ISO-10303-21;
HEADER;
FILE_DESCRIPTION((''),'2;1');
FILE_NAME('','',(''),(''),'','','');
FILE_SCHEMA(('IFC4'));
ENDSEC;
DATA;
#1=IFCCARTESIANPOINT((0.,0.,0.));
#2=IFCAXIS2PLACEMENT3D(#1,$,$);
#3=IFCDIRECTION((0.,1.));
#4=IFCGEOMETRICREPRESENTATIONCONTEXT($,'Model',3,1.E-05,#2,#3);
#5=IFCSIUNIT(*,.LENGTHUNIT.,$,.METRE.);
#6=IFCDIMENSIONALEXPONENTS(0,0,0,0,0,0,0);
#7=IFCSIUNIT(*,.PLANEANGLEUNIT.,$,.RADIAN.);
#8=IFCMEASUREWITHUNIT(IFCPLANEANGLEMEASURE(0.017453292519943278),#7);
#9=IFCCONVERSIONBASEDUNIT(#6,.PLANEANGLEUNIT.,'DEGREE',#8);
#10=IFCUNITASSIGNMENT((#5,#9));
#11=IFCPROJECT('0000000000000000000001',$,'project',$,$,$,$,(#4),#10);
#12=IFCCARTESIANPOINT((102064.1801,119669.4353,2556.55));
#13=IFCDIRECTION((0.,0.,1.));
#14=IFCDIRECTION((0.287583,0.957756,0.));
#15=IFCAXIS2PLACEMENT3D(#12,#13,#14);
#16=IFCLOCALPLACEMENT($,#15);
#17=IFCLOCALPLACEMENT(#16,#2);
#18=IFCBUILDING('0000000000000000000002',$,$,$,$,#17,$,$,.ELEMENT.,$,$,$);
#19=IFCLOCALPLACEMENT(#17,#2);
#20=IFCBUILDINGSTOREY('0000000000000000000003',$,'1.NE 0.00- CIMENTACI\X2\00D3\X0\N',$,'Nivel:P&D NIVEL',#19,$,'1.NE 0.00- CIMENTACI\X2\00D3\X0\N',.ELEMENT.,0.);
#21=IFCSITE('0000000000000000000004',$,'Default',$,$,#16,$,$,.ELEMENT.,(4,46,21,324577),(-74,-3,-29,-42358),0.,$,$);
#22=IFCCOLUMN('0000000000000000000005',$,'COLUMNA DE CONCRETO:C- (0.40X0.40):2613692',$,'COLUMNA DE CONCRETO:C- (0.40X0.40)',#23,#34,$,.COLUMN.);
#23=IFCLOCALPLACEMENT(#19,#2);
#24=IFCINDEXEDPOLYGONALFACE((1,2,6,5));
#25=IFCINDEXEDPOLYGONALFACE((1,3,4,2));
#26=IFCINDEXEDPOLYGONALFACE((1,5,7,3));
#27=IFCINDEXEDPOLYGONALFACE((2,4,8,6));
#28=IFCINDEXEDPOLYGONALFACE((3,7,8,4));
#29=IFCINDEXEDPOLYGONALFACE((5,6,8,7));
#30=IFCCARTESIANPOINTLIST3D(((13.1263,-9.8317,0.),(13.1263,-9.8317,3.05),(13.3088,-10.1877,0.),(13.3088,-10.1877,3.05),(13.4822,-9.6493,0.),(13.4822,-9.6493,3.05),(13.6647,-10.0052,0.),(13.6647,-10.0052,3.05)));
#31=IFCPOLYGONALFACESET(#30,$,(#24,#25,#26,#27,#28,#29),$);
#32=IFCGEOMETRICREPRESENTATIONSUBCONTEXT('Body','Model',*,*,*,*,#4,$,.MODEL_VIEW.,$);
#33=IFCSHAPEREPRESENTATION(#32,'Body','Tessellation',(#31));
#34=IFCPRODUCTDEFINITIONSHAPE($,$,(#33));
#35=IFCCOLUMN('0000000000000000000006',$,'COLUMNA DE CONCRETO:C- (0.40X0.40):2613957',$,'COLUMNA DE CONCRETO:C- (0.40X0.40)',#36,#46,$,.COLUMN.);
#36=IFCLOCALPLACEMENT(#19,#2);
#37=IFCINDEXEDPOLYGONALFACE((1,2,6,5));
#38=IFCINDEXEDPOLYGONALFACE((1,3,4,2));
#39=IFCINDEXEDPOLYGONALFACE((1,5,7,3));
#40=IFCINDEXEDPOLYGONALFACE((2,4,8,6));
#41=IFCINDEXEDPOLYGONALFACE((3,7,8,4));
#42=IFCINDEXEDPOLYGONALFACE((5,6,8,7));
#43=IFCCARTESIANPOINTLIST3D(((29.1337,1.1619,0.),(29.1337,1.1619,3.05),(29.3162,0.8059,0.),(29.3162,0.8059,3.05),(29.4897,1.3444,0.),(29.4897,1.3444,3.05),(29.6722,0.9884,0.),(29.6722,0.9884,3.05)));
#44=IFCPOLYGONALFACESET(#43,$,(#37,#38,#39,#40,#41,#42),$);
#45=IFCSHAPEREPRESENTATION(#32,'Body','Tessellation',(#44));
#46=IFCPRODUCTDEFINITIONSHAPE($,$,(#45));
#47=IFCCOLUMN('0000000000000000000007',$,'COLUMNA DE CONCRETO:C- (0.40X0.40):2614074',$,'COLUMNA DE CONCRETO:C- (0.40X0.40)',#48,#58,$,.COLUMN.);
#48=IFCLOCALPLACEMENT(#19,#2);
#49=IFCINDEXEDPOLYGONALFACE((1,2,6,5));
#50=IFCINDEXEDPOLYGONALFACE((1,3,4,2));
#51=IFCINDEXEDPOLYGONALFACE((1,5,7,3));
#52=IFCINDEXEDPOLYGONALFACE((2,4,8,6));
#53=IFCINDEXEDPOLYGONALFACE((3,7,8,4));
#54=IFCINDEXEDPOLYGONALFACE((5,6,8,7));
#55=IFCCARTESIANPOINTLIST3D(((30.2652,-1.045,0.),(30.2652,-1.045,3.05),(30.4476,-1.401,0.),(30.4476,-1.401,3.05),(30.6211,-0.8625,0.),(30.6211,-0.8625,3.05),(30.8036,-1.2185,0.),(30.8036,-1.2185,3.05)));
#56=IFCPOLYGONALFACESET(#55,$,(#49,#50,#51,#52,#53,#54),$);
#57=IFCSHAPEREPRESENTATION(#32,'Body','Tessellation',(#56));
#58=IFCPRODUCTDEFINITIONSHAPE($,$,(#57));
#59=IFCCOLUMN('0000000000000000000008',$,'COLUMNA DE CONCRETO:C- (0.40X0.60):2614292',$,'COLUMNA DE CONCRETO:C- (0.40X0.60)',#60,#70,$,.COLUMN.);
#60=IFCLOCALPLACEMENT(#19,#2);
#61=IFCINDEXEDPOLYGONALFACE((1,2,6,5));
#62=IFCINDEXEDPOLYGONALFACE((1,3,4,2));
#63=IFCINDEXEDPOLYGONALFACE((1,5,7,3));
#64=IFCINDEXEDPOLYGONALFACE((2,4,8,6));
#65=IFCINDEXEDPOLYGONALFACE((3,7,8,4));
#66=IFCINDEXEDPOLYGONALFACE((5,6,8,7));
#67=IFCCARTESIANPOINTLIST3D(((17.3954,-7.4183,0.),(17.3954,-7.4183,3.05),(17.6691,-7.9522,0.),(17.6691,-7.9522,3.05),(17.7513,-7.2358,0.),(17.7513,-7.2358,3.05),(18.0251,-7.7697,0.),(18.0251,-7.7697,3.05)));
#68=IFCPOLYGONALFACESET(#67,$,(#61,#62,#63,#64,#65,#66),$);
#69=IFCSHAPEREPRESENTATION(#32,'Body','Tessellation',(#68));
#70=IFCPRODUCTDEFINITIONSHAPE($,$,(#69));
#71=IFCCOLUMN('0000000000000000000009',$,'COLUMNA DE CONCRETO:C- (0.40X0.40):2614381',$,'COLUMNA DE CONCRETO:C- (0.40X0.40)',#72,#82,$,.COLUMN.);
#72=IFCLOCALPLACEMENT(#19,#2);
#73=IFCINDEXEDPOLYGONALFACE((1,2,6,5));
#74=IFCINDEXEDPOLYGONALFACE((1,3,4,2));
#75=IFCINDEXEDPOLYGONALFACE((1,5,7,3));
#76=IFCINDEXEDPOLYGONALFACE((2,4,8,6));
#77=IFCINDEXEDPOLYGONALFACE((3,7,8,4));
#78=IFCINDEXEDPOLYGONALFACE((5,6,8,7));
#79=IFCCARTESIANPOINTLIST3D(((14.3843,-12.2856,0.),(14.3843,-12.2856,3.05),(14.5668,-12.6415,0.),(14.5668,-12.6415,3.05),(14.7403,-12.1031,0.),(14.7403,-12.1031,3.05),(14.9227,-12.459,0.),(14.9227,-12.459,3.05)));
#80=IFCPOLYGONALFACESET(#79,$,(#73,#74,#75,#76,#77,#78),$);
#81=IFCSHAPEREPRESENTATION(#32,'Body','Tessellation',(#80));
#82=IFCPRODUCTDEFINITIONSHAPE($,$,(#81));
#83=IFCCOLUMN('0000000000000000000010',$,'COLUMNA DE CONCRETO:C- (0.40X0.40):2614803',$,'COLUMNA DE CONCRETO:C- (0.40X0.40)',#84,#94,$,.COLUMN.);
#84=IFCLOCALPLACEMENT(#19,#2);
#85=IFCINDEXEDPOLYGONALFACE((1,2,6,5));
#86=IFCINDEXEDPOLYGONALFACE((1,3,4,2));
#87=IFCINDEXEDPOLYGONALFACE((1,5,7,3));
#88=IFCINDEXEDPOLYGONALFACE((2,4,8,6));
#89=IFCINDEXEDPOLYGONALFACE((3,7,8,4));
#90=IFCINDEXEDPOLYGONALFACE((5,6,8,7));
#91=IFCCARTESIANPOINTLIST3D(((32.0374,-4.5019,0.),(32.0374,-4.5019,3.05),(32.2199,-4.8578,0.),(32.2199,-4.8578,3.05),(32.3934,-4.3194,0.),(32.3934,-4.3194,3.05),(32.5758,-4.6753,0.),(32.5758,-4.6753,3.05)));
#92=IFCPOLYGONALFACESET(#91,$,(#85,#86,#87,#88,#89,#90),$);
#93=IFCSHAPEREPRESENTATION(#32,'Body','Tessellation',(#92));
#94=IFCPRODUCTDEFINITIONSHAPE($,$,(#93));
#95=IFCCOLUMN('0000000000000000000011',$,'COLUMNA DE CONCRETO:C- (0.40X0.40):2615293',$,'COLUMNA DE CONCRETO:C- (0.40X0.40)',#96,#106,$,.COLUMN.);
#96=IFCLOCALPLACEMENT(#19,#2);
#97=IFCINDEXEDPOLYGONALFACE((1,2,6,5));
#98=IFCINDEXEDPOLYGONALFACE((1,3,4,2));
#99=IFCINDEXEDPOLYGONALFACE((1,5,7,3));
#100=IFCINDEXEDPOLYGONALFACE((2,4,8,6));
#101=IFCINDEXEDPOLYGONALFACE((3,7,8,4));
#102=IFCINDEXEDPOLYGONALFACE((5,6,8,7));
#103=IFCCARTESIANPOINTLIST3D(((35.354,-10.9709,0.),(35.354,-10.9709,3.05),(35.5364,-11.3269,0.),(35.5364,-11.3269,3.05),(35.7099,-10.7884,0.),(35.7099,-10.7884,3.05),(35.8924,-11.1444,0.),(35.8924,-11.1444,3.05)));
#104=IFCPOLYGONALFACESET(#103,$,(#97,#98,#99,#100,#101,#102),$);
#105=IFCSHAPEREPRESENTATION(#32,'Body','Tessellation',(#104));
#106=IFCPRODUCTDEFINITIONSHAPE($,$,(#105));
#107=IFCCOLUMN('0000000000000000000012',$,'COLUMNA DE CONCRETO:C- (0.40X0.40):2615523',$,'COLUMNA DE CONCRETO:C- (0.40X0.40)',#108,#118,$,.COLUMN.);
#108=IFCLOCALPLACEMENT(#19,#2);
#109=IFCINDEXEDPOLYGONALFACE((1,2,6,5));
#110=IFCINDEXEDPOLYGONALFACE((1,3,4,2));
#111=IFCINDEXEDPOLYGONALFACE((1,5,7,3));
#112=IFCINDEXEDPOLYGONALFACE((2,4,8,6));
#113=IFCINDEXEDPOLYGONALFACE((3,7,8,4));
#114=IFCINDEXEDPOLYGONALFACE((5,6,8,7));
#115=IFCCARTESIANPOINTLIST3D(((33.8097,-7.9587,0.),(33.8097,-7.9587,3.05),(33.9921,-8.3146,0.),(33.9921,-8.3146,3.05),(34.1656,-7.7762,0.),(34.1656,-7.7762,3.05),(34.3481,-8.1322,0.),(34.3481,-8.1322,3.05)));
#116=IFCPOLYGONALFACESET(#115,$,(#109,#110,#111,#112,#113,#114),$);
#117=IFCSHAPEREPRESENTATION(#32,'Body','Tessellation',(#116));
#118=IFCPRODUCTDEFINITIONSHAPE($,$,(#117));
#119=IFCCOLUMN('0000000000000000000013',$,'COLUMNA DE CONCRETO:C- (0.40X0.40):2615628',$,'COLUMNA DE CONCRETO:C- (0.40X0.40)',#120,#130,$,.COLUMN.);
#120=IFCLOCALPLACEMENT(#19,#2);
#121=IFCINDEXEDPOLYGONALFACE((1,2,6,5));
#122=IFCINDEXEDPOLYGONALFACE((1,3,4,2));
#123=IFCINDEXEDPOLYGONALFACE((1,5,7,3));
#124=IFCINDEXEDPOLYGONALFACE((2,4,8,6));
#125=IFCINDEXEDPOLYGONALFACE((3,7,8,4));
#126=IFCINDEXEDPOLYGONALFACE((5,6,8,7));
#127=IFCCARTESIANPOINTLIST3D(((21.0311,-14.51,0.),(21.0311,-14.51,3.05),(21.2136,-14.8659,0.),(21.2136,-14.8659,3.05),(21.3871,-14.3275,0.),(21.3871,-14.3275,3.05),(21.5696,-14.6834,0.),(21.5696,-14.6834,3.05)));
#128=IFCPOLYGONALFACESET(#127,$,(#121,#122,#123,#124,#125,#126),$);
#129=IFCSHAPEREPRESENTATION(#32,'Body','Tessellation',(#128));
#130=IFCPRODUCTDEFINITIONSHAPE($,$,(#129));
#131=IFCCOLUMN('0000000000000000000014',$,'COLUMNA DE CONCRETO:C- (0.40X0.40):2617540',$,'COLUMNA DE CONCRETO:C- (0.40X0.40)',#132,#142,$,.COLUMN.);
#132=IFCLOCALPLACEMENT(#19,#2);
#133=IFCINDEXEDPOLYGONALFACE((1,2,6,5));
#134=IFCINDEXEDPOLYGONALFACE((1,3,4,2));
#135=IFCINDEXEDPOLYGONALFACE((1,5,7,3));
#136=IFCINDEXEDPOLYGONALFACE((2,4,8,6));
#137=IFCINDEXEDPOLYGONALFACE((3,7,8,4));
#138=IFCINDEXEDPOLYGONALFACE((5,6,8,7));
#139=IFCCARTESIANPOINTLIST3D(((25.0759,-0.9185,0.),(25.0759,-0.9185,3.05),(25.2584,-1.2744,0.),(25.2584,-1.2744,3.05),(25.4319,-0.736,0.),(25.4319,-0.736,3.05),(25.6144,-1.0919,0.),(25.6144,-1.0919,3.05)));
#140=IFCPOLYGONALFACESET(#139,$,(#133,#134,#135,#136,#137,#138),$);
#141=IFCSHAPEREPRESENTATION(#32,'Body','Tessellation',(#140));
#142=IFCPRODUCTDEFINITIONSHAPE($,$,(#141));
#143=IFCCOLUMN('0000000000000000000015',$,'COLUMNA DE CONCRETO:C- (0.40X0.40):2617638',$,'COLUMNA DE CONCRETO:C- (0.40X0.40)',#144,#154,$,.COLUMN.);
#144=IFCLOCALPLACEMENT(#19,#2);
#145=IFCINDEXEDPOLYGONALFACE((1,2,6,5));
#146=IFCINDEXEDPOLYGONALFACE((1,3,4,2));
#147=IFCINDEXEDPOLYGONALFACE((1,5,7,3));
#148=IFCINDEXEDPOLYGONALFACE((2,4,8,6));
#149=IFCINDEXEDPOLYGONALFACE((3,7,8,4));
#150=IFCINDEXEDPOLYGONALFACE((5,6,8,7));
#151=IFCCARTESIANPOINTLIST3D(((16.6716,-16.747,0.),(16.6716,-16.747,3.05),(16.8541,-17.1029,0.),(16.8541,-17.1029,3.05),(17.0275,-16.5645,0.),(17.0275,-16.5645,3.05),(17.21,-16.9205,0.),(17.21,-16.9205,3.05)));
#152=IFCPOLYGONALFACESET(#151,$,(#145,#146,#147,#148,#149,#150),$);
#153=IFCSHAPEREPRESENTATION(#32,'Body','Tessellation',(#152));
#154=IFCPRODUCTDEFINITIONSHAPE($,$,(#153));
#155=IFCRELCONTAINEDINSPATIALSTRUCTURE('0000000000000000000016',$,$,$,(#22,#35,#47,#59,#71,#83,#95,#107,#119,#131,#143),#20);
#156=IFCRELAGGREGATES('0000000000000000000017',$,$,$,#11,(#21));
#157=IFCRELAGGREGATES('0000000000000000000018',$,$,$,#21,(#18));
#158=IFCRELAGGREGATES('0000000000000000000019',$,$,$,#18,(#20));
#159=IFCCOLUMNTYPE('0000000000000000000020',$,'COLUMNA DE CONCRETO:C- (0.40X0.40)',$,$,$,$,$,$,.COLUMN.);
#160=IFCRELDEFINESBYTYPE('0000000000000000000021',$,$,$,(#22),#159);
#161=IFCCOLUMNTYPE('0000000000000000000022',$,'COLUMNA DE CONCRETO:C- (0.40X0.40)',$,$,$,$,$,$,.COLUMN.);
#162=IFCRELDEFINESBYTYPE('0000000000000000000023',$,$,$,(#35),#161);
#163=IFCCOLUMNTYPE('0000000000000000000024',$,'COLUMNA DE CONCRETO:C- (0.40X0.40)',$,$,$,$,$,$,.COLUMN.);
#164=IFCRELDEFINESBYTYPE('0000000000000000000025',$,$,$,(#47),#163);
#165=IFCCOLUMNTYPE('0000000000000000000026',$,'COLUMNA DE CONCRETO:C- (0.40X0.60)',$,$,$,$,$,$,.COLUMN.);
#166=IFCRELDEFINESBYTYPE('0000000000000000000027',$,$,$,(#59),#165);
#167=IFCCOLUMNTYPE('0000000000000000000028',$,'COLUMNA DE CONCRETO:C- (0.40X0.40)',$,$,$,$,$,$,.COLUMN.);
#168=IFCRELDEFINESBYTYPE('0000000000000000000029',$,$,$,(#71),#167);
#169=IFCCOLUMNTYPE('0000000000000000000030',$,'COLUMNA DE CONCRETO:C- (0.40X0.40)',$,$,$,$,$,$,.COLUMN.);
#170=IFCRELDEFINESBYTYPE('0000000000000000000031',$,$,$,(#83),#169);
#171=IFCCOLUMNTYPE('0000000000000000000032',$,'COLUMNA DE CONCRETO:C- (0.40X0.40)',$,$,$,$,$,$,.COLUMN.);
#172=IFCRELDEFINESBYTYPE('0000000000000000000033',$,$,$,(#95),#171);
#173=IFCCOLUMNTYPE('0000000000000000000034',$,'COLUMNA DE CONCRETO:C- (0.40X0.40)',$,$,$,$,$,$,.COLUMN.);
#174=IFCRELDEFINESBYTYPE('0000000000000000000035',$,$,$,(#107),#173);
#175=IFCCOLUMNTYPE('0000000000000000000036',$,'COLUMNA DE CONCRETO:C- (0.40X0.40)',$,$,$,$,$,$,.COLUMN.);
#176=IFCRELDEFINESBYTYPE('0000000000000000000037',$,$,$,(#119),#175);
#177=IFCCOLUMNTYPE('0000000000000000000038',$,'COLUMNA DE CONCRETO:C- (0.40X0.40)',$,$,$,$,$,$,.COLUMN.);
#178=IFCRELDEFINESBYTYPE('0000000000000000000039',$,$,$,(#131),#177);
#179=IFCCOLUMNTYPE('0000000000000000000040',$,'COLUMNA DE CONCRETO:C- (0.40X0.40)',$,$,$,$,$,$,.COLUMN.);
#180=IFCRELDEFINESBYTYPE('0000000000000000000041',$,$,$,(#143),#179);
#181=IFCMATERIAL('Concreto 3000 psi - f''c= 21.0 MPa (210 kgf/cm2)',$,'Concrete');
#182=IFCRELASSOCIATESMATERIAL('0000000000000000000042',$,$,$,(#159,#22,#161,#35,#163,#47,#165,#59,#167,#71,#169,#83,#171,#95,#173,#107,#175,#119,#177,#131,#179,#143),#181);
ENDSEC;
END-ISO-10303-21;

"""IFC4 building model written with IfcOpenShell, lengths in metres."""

from ifc_helpers import new_model, entity, si_unit, converted_unit, direction, frame, origin, place, context, subcontext, project, spatial, indexed_curve, outline, extrude, source, transform, mapped, material, type_object, type_shapes, element, save


model = new_model("IFC4")

# Units and contexts
model_context = context("Model", 3, precision=1e-05, world=origin(), true_north=direction((0.0, 1.0)))
body_context = subcontext(model_context, "Body", "Model", "MODEL_VIEW")
ifc_project = project(units=[si_unit("LENGTHUNIT", "METRE"), converted_unit("PLANEANGLEUNIT", "DEGREE", entity("IfcPlaneAngleMeasure", 0.017453292519943278), si_unit("PLANEANGLEUNIT", "RADIAN"), dimensions=[0, 0, 0, 0, 0, 0, 0])], contexts=[model_context])

# Site, building, storey
site_placement = place(None, frame((102064.1801, 119669.4353, 2556.55), z_axis=(0.0, 0.0, 1.0), x_axis=(0.287583, 0.957756, 0.0)))
site = spatial("IfcSite", under=ifc_project, at=site_placement, Name="Default", CompositionType="ELEMENT", RefLatitude=(4, 46, 21, 324577), RefLongitude=(-74, -3, -29, -42358), RefElevation=0.0)
building_placement = place(site_placement, origin())
building = spatial("IfcBuilding", under=site, at=building_placement, CompositionType="ELEMENT")
storey_placement = place(building_placement, origin())
storey = spatial("IfcBuildingStorey", under=building, at=storey_placement, Name="1.NE 0.00- CIMENTACIÓN", ObjectType="Nivel:P&D NIVEL", LongName="1.NE 0.00- CIMENTACIÓN", CompositionType="ELEMENT", Elevation=0.0)

# Columns
ifc_material = material(Name="Concreto 3000 psi - f'c= 21.0 MPa (210 kgf/cm2)", Category="Concrete")
column_type_1 = type_object("IfcColumnType", Name="COLUMNA DE CONCRETO:C- (0.40X0.40)", PredefinedType="COLUMN", material=ifc_material)
shared_shape_1 = source(origin(), body_context, "Body", "SweptSolid", [
    extrude(outline(indexed_curve([(-0.2, -0.2), (0.2, -0.2), (0.2, 0.2), (-0.2, 0.2), (-0.2, -0.2)], self_intersect=False)), frame((13.3955, -9.9185, 0.0), z_axis=(0.0, 0.0, 1.0), x_axis=(-0.889869, -0.456217, 0.0)), (0.0, 0.0, 1.0), 3.05),
])
type_shapes(column_type_1, [shared_shape_1])
column_1_placement = place(storey_placement, origin())
element("IfcColumn", 1, at=column_1_placement, inside=storey, type_object=column_type_1, material=ifc_material, Name="COLUMNA DE CONCRETO:C- (0.40X0.40):2613692", ObjectType="COLUMNA DE CONCRETO:C- (0.40X0.40)", PredefinedType="COLUMN", context=body_context, shape_type="MappedRepresentation", body=[
    mapped(shared_shape_1, transform((0.0, 0.0, 0.0), scale=1.0)),
])
column_type_2 = type_object("IfcColumnType", Name="COLUMNA DE CONCRETO:C- (0.40X0.40)", PredefinedType="COLUMN", material=ifc_material)
shared_shape_2 = source(origin(), body_context, "Body", "SweptSolid", [
    extrude(outline(indexed_curve([(-0.2, -0.2), (0.2, -0.2), (0.2, 0.2), (-0.2, 0.2), (-0.2, -0.2)], self_intersect=False)), frame((29.403, 1.0751, 0.0), z_axis=(0.0, 0.0, 1.0), x_axis=(-0.889869, -0.456217, 0.0)), (0.0, 0.0, 1.0), 3.05),
])
type_shapes(column_type_2, [shared_shape_2])
column_2_placement = place(storey_placement, origin())
element("IfcColumn", 2, at=column_2_placement, inside=storey, type_object=column_type_2, material=ifc_material, Name="COLUMNA DE CONCRETO:C- (0.40X0.40):2613957", ObjectType="COLUMNA DE CONCRETO:C- (0.40X0.40)", PredefinedType="COLUMN", context=body_context, shape_type="MappedRepresentation", body=[
    mapped(shared_shape_2, transform((0.0, 0.0, 0.0), scale=1.0)),
])
column_type_3 = type_object("IfcColumnType", Name="COLUMNA DE CONCRETO:C- (0.40X0.40)", PredefinedType="COLUMN", material=ifc_material)
shared_shape_3 = source(origin(), body_context, "Body", "SweptSolid", [
    extrude(outline(indexed_curve([(-0.2, -0.2), (0.2, -0.2), (0.2, 0.2), (-0.2, 0.2), (-0.2, -0.2)], self_intersect=False)), frame((30.5344, -1.1317, 0.0), z_axis=(0.0, 0.0, 1.0), x_axis=(-0.889869, -0.456217, 0.0)), (0.0, 0.0, 1.0), 3.05),
])
type_shapes(column_type_3, [shared_shape_3])
column_3_placement = place(storey_placement, origin())
element("IfcColumn", 3, at=column_3_placement, inside=storey, type_object=column_type_3, material=ifc_material, Name="COLUMNA DE CONCRETO:C- (0.40X0.40):2614074", ObjectType="COLUMNA DE CONCRETO:C- (0.40X0.40)", PredefinedType="COLUMN", context=body_context, shape_type="MappedRepresentation", body=[
    mapped(shared_shape_3, transform((0.0, 0.0, 0.0), scale=1.0)),
])
column_type_4 = type_object("IfcColumnType", Name="COLUMNA DE CONCRETO:C- (0.40X0.60)", PredefinedType="COLUMN", material=ifc_material)
shared_shape_4 = source(origin(), body_context, "Body", "SweptSolid", [
    extrude(outline(indexed_curve([(-0.2, -0.3), (0.2, -0.3), (0.2, 0.3), (-0.2, 0.3), (-0.2, -0.3)], self_intersect=False)), frame((17.7102, -7.594, 0.0), z_axis=(0.0, 0.0, 1.0), x_axis=(-0.889869, -0.456217, 0.0)), (0.0, 0.0, 1.0), 3.05),
])
type_shapes(column_type_4, [shared_shape_4])
column_4_placement = place(storey_placement, origin())
element("IfcColumn", 4, at=column_4_placement, inside=storey, type_object=column_type_4, material=ifc_material, Name="COLUMNA DE CONCRETO:C- (0.40X0.60):2614292", ObjectType="COLUMNA DE CONCRETO:C- (0.40X0.60)", PredefinedType="COLUMN", context=body_context, shape_type="MappedRepresentation", body=[
    mapped(shared_shape_4, transform((0.0, 0.0, 0.0), scale=1.0)),
])
column_type_5 = type_object("IfcColumnType", Name="COLUMNA DE CONCRETO:C- (0.40X0.40)", PredefinedType="COLUMN", material=ifc_material)
shared_shape_5 = source(origin(), body_context, "Body", "SweptSolid", [
    extrude(outline(indexed_curve([(-0.2, -0.2), (0.2, -0.2), (0.2, 0.2), (-0.2, 0.2), (-0.2, -0.2)], self_intersect=False)), frame((14.6535, -12.3723, 0.0), z_axis=(0.0, 0.0, 1.0), x_axis=(-0.889869, -0.456217, 0.0)), (0.0, 0.0, 1.0), 3.05),
])
type_shapes(column_type_5, [shared_shape_5])
column_5_placement = place(storey_placement, origin())
element("IfcColumn", 5, at=column_5_placement, inside=storey, type_object=column_type_5, material=ifc_material, Name="COLUMNA DE CONCRETO:C- (0.40X0.40):2614381", ObjectType="COLUMNA DE CONCRETO:C- (0.40X0.40)", PredefinedType="COLUMN", context=body_context, shape_type="MappedRepresentation", body=[
    mapped(shared_shape_5, transform((0.0, 0.0, 0.0), scale=1.0)),
])
column_type_6 = type_object("IfcColumnType", Name="COLUMNA DE CONCRETO:C- (0.40X0.40)", PredefinedType="COLUMN", material=ifc_material)
shared_shape_6 = source(origin(), body_context, "Body", "SweptSolid", [
    extrude(outline(indexed_curve([(-0.2, -0.2), (0.2, -0.2), (0.2, 0.2), (-0.2, 0.2), (-0.2, -0.2)], self_intersect=False)), frame((32.3066, -4.5886, 0.0), z_axis=(0.0, 0.0, 1.0), x_axis=(-0.889869, -0.456217, 0.0)), (0.0, 0.0, 1.0), 3.05),
])
type_shapes(column_type_6, [shared_shape_6])
column_6_placement = place(storey_placement, origin())
element("IfcColumn", 6, at=column_6_placement, inside=storey, type_object=column_type_6, material=ifc_material, Name="COLUMNA DE CONCRETO:C- (0.40X0.40):2614803", ObjectType="COLUMNA DE CONCRETO:C- (0.40X0.40)", PredefinedType="COLUMN", context=body_context, shape_type="MappedRepresentation", body=[
    mapped(shared_shape_6, transform((0.0, 0.0, 0.0), scale=1.0)),
])
column_type_7 = type_object("IfcColumnType", Name="COLUMNA DE CONCRETO:C- (0.40X0.40)", PredefinedType="COLUMN", material=ifc_material)
shared_shape_7 = source(origin(), body_context, "Body", "SweptSolid", [
    extrude(outline(indexed_curve([(-0.2, -0.2), (0.2, -0.2), (0.2, 0.2), (-0.2, 0.2), (-0.2, -0.2)], self_intersect=False)), frame((35.6232, -11.0576, 0.0), z_axis=(0.0, 0.0, 1.0), x_axis=(-0.889869, -0.456217, 0.0)), (0.0, 0.0, 1.0), 3.05),
])
type_shapes(column_type_7, [shared_shape_7])
column_7_placement = place(storey_placement, origin())
element("IfcColumn", 7, at=column_7_placement, inside=storey, type_object=column_type_7, material=ifc_material, Name="COLUMNA DE CONCRETO:C- (0.40X0.40):2615293", ObjectType="COLUMNA DE CONCRETO:C- (0.40X0.40)", PredefinedType="COLUMN", context=body_context, shape_type="MappedRepresentation", body=[
    mapped(shared_shape_7, transform((0.0, 0.0, 0.0), scale=1.0)),
])
column_type_8 = type_object("IfcColumnType", Name="COLUMNA DE CONCRETO:C- (0.40X0.40)", PredefinedType="COLUMN", material=ifc_material)
shared_shape_8 = source(origin(), body_context, "Body", "SweptSolid", [
    extrude(outline(indexed_curve([(-0.2, -0.2), (0.2, -0.2), (0.2, 0.2), (-0.2, 0.2), (-0.2, -0.2)], self_intersect=False)), frame((34.0789, -8.0454, 0.0), z_axis=(0.0, 0.0, 1.0), x_axis=(-0.889869, -0.456217, 0.0)), (0.0, 0.0, 1.0), 3.05),
])
type_shapes(column_type_8, [shared_shape_8])
column_8_placement = place(storey_placement, origin())
element("IfcColumn", 8, at=column_8_placement, inside=storey, type_object=column_type_8, material=ifc_material, Name="COLUMNA DE CONCRETO:C- (0.40X0.40):2615523", ObjectType="COLUMNA DE CONCRETO:C- (0.40X0.40)", PredefinedType="COLUMN", context=body_context, shape_type="MappedRepresentation", body=[
    mapped(shared_shape_8, transform((0.0, 0.0, 0.0), scale=1.0)),
])
column_type_9 = type_object("IfcColumnType", Name="COLUMNA DE CONCRETO:C- (0.40X0.40)", PredefinedType="COLUMN", material=ifc_material)
shared_shape_9 = source(origin(), body_context, "Body", "SweptSolid", [
    extrude(outline(indexed_curve([(-0.2, -0.2), (0.2, -0.2), (0.2, 0.2), (-0.2, 0.2), (-0.2, -0.2)], self_intersect=False)), frame((21.3004, -14.5967, 0.0), z_axis=(0.0, 0.0, 1.0), x_axis=(-0.889869, -0.456217, 0.0)), (0.0, 0.0, 1.0), 3.05),
])
type_shapes(column_type_9, [shared_shape_9])
column_9_placement = place(storey_placement, origin())
element("IfcColumn", 9, at=column_9_placement, inside=storey, type_object=column_type_9, material=ifc_material, Name="COLUMNA DE CONCRETO:C- (0.40X0.40):2615628", ObjectType="COLUMNA DE CONCRETO:C- (0.40X0.40)", PredefinedType="COLUMN", context=body_context, shape_type="MappedRepresentation", body=[
    mapped(shared_shape_9, transform((0.0, 0.0, 0.0), scale=1.0)),
])
column_type_10 = type_object("IfcColumnType", Name="COLUMNA DE CONCRETO:C- (0.40X0.40)", PredefinedType="COLUMN", material=ifc_material)
shared_shape_10 = source(origin(), body_context, "Body", "SweptSolid", [
    extrude(outline(indexed_curve([(-0.2, -0.2), (0.2, -0.2), (0.2, 0.2), (-0.2, 0.2), (-0.2, -0.2)], self_intersect=False)), frame((25.3452, -1.0052, 0.0), z_axis=(0.0, 0.0, 1.0), x_axis=(-0.889869, -0.456217, 0.0)), (0.0, 0.0, 1.0), 3.05),
])
type_shapes(column_type_10, [shared_shape_10])
column_10_placement = place(storey_placement, origin())
element("IfcColumn", 10, at=column_10_placement, inside=storey, type_object=column_type_10, material=ifc_material, Name="COLUMNA DE CONCRETO:C- (0.40X0.40):2617540", ObjectType="COLUMNA DE CONCRETO:C- (0.40X0.40)", PredefinedType="COLUMN", context=body_context, shape_type="MappedRepresentation", body=[
    mapped(shared_shape_10, transform((0.0, 0.0, 0.0), scale=1.0)),
])
column_type_11 = type_object("IfcColumnType", Name="COLUMNA DE CONCRETO:C- (0.40X0.40)", PredefinedType="COLUMN", material=ifc_material)
shared_shape_11 = source(origin(), body_context, "Body", "SweptSolid", [
    extrude(outline(indexed_curve([(-0.2, -0.2), (0.2, -0.2), (0.2, 0.2), (-0.2, 0.2), (-0.2, -0.2)], self_intersect=False)), frame((16.9408, -16.8337, 0.0), z_axis=(0.0, 0.0, 1.0), x_axis=(-0.889869, -0.456217, 0.0)), (0.0, 0.0, 1.0), 3.05),
])
type_shapes(column_type_11, [shared_shape_11])
column_11_placement = place(storey_placement, origin())
element("IfcColumn", 11, at=column_11_placement, inside=storey, type_object=column_type_11, material=ifc_material, Name="COLUMNA DE CONCRETO:C- (0.40X0.40):2617638", ObjectType="COLUMNA DE CONCRETO:C- (0.40X0.40)", PredefinedType="COLUMN", context=body_context, shape_type="MappedRepresentation", body=[
    mapped(shared_shape_11, transform((0.0, 0.0, 0.0), scale=1.0)),
])

save(model, "model.ifc")
